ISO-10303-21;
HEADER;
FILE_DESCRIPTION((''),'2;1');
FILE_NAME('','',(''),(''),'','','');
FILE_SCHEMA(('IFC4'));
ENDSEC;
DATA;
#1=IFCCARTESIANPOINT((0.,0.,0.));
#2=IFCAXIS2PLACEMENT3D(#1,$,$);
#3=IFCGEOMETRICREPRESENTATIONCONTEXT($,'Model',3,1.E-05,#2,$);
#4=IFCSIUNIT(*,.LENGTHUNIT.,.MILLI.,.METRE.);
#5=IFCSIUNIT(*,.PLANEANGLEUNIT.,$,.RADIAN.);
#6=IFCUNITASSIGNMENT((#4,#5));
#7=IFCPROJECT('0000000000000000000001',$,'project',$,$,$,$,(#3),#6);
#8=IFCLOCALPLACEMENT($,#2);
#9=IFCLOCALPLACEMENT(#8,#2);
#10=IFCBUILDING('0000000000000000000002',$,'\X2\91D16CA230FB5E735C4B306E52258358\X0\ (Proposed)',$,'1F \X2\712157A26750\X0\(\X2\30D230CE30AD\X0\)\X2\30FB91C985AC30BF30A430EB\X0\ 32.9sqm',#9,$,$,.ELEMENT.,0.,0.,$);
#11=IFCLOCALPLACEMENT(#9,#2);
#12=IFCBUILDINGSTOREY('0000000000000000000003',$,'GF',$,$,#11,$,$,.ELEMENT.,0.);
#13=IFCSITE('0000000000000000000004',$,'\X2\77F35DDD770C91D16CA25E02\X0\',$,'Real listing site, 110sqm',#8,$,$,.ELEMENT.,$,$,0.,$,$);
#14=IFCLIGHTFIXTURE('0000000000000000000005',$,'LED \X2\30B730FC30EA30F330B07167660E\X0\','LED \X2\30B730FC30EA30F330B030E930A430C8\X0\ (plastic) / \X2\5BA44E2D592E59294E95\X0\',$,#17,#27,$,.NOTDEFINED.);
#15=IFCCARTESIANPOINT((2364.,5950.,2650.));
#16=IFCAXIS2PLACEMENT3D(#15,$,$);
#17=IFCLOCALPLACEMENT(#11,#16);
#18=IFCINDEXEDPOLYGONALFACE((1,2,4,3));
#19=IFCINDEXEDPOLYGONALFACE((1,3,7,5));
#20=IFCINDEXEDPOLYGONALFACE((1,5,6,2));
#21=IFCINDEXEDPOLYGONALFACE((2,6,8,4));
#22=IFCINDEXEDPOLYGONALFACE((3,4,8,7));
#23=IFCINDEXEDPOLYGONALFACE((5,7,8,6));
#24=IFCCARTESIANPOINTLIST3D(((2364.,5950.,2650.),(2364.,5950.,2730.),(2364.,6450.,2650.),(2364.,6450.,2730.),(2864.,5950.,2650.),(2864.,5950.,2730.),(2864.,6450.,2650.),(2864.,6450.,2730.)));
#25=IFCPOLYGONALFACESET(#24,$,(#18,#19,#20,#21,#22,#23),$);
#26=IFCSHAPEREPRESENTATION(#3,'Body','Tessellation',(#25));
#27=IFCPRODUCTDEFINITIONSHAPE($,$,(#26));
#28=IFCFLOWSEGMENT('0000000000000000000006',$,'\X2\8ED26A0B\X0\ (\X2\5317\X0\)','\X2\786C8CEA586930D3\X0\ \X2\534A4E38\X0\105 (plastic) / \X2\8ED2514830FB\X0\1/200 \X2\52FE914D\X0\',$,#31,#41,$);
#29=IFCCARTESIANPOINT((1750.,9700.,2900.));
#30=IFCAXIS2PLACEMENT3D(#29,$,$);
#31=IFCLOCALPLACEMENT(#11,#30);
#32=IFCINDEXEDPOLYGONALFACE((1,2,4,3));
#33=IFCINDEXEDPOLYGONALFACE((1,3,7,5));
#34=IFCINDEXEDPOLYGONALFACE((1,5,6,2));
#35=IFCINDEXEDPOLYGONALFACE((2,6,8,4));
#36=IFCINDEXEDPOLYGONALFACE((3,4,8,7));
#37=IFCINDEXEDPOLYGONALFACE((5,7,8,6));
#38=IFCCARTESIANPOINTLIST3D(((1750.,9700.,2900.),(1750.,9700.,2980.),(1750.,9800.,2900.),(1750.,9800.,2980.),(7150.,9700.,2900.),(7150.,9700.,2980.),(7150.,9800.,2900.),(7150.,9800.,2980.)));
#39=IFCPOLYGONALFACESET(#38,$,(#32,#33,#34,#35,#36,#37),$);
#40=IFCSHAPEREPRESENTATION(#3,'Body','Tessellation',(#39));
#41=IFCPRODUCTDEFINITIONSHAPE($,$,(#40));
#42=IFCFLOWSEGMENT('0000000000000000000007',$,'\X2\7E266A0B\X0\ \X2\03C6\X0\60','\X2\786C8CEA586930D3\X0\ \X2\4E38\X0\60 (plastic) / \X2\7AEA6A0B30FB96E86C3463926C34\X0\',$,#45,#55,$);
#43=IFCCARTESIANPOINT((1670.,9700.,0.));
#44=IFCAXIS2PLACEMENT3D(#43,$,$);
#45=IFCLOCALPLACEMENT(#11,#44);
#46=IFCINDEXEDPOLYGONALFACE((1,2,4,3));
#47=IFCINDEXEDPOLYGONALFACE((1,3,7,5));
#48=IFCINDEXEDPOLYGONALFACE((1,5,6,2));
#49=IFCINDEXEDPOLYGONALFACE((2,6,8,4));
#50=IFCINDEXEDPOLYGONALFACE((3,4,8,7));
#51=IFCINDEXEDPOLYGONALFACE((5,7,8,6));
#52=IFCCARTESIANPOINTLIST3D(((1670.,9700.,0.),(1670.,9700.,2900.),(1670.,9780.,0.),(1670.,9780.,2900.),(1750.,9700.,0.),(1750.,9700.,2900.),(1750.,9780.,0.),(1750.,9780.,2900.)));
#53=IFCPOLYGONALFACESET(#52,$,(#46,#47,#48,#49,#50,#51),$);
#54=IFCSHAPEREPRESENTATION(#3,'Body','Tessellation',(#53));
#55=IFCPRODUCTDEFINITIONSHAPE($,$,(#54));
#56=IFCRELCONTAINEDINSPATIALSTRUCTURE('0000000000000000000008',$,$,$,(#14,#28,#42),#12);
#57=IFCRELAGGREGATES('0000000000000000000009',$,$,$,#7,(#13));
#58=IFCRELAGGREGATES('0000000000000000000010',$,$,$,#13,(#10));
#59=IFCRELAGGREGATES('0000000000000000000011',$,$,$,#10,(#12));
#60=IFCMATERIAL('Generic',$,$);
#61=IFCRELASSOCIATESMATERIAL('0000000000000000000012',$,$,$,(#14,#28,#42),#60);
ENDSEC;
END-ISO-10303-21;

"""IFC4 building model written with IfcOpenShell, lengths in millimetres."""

from ifc_helpers import new_model, si_unit, frame, frame_2d, origin, place, context, project, spatial, rectangle, extrude, material, element, save


model = new_model("IFC4")

# Units and contexts
model_context = context("Model", 3, precision=1e-05, world=origin())
ifc_project = project(units=[si_unit("LENGTHUNIT", "METRE", prefix="MILLI"), si_unit("PLANEANGLEUNIT", "RADIAN")], contexts=[model_context])

# Site, building, storey
site_placement = place(None, origin())
site = spatial("IfcSite", under=ifc_project, at=site_placement, Name="石川県金沢市", ObjectType="Real listing site, 110sqm", CompositionType="ELEMENT", RefElevation=0.0)
building_placement = place(site_placement, origin())
building = spatial("IfcBuilding", under=site, at=building_placement, Name="金沢・平屋の別荘 (Proposed)", ObjectType="1F 無垢材(ヒノキ)・釉薬タイル 32.9sqm", CompositionType="ELEMENT", ElevationOfRefHeight=0.0, ElevationOfTerrain=0.0)
storey_placement = place(building_placement, origin())
storey = spatial("IfcBuildingStorey", under=building, at=storey_placement, Name="GF", CompositionType="ELEMENT", Elevation=0.0)

# Shared definitions
ifc_material_1 = material(Name="Generic")

# Light fixture
light_fixture_placement = place(storey_placement, frame((2364.0, 5950.0, 2650.0)))
element("IfcLightFixture", 1, at=light_fixture_placement, inside=storey, material=ifc_material_1, Name="LED シーリング照明", Description="LED シーリングライト (plastic) / 室中央天井", PredefinedType="NOTDEFINED", context=model_context, shape_type="SweptSolid", body=[
    extrude(rectangle(XDim=500.0, YDim=500.0, at=frame_2d((250.0, 250.0))), frame((2364.0, 5950.0, 2650.0)), (0.0, 0.0, 1.0), 80.0),
])

# Flow segments
flow_segment_1_placement = place(storey_placement, frame((1750.0, 9700.0, 2900.0)))
element("IfcFlowSegment", 2, at=flow_segment_1_placement, inside=storey, material=ifc_material_1, Name="軒樋 (北)", Description="硬質塩ビ 半丸105 (plastic) / 軒先・1/200 勾配", context=model_context, shape_type="SweptSolid", body=[
    extrude(rectangle(XDim=5400.0, YDim=100.0, at=frame_2d((2700.0, 50.0))), frame((1750.0, 9700.0, 2900.0)), (0.0, 0.0, 1.0), 80.0),
])
flow_segment_2_placement = place(storey_placement, frame((1670.0, 9700.0, 0.0)))
element("IfcFlowSegment", 3, at=flow_segment_2_placement, inside=storey, material=ifc_material_1, Name="縦樋 φ60", Description="硬質塩ビ 丸60 (plastic) / 竪樋・雨水排水", context=model_context, shape_type="SweptSolid", body=[
    extrude(rectangle(XDim=80.0, YDim=80.0, at=frame_2d((40.0, 40.0))), frame((1670.0, 9700.0, 0.0)), (0.0, 0.0, 1.0), 2900.0),
])

save(model, "model.ifc")
